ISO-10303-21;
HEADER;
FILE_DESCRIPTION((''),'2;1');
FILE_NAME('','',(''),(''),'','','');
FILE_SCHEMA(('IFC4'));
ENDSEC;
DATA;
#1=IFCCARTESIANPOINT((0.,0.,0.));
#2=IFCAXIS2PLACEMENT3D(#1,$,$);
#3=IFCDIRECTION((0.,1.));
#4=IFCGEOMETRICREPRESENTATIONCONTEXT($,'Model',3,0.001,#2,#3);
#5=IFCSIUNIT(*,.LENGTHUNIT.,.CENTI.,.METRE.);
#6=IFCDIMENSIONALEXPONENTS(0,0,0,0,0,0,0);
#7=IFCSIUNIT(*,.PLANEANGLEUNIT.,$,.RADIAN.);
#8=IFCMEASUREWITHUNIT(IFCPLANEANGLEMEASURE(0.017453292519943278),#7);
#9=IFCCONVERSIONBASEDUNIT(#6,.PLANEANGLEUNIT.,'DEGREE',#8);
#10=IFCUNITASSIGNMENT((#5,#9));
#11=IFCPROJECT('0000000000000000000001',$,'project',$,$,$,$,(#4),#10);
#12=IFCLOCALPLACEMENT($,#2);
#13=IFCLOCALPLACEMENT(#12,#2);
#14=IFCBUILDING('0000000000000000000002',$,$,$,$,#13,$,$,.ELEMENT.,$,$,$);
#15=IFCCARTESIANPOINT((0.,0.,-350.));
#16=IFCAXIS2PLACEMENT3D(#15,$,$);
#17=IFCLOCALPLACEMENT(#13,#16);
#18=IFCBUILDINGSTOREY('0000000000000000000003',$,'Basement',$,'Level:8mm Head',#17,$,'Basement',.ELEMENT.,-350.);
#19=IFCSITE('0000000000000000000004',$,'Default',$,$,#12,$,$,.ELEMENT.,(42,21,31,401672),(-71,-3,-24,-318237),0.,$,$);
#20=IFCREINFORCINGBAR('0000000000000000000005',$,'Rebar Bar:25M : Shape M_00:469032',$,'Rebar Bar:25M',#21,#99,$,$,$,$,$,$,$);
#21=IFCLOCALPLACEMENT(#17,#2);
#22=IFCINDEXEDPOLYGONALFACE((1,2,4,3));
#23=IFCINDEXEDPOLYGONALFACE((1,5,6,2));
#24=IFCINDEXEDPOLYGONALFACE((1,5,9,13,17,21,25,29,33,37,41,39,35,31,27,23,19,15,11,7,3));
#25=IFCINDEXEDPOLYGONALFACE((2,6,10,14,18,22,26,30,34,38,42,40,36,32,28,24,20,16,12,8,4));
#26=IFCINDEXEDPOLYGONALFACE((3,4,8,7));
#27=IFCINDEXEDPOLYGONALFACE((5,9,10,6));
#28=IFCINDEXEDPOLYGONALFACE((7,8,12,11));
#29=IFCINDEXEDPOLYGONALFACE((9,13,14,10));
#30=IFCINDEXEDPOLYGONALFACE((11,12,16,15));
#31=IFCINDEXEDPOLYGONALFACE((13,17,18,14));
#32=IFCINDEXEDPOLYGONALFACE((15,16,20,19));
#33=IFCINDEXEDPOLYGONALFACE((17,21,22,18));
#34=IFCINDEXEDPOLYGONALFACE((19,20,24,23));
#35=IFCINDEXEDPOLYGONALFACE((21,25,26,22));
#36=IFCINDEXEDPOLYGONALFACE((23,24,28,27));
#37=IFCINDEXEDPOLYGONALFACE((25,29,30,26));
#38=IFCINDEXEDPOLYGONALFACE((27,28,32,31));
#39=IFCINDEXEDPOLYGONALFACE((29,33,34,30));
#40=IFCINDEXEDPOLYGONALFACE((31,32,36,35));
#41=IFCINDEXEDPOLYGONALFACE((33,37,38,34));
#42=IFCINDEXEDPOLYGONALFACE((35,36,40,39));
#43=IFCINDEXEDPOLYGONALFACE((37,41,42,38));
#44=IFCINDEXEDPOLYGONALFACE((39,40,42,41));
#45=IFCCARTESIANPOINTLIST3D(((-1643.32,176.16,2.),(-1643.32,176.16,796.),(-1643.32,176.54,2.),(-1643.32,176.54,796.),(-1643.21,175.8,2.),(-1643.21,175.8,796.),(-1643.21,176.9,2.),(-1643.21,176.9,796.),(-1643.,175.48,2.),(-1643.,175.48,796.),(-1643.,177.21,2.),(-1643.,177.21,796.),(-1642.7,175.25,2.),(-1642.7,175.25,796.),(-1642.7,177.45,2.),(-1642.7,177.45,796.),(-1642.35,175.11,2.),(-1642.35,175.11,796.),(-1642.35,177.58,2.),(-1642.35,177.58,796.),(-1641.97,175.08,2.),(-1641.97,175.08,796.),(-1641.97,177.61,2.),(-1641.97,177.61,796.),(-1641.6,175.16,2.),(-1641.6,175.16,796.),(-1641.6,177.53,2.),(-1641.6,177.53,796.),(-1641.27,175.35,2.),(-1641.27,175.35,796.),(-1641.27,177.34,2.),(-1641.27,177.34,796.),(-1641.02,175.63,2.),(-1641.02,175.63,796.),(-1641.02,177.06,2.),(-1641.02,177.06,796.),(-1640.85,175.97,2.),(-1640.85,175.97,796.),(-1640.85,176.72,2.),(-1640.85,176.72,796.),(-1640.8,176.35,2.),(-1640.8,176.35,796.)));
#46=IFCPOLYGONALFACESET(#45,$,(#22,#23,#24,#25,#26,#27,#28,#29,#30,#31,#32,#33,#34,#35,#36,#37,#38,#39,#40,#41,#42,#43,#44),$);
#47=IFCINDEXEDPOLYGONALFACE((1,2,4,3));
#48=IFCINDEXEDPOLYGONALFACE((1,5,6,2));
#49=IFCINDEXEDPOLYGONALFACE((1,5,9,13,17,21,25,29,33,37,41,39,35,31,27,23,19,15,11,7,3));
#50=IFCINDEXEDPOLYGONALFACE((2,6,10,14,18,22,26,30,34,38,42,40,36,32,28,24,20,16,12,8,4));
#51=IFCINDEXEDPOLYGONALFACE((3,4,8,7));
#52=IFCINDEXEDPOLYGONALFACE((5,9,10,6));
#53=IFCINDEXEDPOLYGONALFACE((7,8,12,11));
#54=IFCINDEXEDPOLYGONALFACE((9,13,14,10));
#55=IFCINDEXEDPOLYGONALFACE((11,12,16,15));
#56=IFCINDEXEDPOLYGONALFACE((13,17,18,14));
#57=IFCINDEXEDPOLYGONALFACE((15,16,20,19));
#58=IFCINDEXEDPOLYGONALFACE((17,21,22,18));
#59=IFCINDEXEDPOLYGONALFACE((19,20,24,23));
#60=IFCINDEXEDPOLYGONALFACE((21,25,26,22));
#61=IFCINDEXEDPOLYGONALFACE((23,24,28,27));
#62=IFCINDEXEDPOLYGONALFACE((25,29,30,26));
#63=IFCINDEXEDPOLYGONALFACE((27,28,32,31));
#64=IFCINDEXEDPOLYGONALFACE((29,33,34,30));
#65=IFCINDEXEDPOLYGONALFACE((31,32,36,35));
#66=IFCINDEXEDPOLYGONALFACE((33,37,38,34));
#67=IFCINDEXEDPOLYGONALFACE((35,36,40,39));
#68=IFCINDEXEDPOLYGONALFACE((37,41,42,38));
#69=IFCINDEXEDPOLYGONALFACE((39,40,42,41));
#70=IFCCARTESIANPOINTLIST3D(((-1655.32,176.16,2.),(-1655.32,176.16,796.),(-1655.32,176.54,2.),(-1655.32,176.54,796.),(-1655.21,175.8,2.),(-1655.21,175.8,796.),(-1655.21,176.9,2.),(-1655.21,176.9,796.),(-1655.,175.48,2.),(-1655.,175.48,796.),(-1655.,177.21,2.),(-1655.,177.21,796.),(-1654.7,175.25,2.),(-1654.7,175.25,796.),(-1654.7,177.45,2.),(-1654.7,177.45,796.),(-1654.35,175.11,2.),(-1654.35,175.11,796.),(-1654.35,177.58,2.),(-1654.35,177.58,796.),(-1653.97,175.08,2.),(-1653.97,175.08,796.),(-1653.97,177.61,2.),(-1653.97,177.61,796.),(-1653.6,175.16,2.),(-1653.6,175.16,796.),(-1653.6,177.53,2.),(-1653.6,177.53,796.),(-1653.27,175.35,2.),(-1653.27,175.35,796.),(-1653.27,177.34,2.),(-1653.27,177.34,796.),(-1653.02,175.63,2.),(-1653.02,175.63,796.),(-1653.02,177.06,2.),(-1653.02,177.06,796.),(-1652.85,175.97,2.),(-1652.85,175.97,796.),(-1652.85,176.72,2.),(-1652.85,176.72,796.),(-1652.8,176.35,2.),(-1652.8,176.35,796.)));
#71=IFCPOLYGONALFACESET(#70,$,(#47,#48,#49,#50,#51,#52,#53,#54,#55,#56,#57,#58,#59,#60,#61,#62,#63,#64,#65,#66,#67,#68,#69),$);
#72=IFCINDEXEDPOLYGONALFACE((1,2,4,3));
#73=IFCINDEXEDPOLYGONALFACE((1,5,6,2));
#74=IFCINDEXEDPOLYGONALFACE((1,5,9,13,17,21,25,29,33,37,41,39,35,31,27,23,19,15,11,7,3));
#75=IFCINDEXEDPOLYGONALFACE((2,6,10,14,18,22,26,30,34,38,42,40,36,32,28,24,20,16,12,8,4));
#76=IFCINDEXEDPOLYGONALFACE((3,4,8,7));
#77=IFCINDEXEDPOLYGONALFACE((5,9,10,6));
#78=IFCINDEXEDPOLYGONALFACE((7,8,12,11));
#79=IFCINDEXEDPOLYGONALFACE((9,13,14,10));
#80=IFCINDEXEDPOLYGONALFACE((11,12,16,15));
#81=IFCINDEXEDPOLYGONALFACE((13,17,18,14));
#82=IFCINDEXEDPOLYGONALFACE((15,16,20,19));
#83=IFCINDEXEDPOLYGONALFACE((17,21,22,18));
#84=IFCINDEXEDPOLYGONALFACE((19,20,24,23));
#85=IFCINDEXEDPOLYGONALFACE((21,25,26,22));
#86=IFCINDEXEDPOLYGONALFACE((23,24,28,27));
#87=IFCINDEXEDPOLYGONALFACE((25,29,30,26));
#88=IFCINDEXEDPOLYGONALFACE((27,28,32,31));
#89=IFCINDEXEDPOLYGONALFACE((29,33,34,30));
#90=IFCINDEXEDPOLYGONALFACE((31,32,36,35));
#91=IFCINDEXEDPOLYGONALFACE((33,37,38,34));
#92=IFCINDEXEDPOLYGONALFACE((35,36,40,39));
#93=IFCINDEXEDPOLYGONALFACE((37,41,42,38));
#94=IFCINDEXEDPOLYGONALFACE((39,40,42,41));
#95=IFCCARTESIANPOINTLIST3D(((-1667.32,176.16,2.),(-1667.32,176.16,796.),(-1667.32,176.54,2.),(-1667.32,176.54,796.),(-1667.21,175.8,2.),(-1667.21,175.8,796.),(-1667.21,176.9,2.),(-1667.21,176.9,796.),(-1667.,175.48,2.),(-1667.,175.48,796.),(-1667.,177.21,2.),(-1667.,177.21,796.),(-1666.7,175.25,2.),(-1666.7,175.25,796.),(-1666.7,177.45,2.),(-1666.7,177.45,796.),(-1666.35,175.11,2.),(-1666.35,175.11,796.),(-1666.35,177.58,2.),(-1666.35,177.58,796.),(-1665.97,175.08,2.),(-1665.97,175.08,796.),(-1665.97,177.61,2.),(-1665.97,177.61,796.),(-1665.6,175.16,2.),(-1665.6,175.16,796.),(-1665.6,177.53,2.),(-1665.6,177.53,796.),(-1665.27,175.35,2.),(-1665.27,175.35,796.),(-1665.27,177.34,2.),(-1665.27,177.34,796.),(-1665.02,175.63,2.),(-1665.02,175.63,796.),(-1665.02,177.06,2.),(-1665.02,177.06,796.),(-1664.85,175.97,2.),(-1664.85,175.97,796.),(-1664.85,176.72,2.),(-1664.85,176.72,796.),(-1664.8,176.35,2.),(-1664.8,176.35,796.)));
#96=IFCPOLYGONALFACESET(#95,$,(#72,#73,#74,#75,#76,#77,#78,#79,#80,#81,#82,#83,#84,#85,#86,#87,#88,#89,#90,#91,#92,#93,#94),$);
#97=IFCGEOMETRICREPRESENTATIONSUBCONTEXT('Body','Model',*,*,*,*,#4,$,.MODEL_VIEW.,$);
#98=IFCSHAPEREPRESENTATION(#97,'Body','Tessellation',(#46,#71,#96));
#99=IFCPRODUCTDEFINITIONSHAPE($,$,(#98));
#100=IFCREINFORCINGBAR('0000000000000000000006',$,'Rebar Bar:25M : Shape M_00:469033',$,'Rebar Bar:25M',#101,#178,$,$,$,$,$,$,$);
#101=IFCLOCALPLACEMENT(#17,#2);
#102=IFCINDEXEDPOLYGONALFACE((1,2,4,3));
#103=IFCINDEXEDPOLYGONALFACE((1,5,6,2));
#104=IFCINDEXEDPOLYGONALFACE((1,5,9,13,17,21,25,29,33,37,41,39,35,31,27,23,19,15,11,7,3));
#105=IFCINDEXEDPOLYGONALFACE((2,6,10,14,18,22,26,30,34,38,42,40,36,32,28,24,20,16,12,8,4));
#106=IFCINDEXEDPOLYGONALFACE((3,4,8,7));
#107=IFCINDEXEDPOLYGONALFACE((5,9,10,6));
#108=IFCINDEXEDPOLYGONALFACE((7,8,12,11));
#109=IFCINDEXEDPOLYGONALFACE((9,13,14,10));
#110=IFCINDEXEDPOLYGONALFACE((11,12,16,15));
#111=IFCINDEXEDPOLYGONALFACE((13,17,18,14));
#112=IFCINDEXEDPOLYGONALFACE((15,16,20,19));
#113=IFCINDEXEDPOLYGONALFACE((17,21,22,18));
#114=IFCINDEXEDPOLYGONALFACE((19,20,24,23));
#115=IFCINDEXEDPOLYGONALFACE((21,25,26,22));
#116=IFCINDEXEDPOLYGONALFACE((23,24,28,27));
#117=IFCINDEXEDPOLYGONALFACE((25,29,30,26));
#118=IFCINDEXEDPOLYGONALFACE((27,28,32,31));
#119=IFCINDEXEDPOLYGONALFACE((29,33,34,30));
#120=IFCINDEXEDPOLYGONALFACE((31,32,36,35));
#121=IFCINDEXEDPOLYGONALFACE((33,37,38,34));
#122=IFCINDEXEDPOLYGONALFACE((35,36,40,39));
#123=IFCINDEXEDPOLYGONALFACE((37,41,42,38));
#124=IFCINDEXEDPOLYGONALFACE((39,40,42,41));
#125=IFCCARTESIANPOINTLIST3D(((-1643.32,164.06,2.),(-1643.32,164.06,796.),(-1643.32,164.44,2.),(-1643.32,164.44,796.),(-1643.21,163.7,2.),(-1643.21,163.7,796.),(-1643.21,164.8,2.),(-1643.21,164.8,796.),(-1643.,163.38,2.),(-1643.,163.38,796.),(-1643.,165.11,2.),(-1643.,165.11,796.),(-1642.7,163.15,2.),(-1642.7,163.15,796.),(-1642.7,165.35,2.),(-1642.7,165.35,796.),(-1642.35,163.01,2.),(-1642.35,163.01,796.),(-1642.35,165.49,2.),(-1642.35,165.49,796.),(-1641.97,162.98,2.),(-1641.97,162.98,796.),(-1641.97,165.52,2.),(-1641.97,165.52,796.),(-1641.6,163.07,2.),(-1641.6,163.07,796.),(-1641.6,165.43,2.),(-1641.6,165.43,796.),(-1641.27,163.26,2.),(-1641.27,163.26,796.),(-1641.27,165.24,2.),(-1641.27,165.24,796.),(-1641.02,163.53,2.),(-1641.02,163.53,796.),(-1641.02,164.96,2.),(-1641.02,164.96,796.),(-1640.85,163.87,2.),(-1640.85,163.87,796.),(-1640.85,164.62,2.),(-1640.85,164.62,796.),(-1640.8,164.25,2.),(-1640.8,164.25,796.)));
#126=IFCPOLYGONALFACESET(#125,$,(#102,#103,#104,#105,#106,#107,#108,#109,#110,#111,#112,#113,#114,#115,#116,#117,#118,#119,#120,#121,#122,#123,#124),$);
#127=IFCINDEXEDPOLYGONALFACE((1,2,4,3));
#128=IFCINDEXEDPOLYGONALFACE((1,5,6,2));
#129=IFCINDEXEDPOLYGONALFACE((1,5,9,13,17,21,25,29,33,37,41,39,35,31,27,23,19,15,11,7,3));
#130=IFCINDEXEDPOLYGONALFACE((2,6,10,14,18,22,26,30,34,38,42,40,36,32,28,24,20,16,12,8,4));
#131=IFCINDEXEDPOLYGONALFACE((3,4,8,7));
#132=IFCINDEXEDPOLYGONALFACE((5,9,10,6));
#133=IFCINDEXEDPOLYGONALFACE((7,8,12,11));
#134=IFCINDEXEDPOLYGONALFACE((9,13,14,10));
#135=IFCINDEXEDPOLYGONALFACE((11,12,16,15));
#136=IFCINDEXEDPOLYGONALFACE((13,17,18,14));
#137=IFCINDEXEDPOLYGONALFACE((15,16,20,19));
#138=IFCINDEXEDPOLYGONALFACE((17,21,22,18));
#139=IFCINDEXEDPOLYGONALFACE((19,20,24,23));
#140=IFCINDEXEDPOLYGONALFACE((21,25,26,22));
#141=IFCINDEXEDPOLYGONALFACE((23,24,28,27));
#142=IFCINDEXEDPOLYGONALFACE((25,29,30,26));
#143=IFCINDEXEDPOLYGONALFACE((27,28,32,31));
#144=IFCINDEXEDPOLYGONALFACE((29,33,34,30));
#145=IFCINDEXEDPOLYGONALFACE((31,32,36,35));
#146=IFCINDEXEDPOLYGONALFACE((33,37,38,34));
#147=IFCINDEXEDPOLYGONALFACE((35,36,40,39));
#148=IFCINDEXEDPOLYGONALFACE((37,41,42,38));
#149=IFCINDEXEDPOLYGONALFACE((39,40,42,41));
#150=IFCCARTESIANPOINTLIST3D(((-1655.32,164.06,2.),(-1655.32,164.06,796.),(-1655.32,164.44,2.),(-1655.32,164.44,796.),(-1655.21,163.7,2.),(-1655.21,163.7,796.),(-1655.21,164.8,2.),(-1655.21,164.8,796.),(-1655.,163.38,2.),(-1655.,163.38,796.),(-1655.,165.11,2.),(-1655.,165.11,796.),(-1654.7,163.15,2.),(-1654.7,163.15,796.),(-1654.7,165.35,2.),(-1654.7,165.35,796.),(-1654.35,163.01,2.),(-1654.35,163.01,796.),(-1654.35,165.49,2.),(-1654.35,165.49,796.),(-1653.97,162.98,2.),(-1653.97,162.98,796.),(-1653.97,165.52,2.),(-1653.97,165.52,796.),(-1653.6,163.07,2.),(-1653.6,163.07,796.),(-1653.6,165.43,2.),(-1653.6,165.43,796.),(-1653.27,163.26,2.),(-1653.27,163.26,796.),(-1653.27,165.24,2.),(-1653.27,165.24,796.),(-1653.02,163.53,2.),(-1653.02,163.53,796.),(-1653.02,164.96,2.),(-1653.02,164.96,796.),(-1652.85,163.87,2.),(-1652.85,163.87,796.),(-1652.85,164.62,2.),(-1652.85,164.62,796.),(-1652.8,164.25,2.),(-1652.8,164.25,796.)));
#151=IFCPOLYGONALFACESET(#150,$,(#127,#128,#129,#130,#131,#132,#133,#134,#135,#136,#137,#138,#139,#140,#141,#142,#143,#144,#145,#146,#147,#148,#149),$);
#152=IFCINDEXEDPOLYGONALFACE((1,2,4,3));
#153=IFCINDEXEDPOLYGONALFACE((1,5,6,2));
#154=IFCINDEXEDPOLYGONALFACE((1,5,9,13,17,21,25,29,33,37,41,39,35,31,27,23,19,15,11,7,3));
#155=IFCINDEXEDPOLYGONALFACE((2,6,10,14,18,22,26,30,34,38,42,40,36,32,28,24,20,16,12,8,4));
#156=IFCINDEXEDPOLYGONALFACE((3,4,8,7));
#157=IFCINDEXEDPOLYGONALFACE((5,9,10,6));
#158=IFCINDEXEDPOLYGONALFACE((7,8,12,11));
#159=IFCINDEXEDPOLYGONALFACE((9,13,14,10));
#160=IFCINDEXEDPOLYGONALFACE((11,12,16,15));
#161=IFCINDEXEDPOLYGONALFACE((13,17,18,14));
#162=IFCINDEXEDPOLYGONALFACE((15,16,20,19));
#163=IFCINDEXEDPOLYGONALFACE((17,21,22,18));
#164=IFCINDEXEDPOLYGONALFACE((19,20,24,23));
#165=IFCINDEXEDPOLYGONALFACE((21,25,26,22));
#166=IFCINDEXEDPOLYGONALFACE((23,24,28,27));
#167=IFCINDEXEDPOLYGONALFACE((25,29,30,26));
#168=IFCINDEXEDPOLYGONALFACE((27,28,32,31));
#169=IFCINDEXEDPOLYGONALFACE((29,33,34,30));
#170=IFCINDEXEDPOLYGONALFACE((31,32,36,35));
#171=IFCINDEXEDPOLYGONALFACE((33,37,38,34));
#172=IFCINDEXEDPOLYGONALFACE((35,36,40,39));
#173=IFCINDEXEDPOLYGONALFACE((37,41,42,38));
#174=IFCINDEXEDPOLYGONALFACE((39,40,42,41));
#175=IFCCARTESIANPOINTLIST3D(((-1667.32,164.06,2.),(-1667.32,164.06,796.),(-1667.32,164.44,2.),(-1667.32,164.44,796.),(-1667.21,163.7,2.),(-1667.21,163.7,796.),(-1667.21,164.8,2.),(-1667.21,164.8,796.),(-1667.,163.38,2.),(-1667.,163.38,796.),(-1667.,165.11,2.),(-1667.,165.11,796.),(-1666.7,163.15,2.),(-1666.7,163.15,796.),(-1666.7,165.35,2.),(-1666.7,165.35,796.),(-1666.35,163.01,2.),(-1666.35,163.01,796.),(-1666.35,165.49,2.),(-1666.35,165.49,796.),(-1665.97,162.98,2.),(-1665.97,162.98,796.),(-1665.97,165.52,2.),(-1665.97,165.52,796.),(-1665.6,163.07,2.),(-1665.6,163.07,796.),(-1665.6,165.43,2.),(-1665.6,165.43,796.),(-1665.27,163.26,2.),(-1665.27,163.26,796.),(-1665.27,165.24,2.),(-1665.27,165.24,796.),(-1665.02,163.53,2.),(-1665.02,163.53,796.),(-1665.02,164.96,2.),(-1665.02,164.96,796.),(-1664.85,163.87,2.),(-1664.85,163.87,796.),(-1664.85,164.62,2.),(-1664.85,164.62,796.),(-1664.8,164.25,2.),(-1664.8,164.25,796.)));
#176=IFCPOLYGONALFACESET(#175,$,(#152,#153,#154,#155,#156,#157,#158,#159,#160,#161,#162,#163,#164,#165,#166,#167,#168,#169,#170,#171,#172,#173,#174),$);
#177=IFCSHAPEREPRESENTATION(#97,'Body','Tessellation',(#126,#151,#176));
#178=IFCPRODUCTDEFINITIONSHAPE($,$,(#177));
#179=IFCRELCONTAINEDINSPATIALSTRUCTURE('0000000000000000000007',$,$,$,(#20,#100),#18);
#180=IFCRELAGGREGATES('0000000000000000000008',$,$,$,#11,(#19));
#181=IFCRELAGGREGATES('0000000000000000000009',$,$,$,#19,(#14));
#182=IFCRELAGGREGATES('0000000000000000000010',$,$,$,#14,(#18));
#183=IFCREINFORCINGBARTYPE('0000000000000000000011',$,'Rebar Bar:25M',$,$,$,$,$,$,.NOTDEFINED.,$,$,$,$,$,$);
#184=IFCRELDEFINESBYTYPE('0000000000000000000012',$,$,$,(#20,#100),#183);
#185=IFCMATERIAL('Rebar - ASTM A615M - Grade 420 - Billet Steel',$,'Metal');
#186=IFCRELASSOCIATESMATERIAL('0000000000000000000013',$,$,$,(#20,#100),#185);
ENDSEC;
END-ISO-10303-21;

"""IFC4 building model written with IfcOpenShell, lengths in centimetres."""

from ifc_helpers import new_model, entity, si_unit, converted_unit, direction, frame, origin, place, context, subcontext, project, spatial, material, type_object, element, save


model = new_model("IFC4")

# Units and contexts
model_context = context("Model", 3, precision=0.001, world=origin(), true_north=direction((0.0, 1.0)))
body_context = subcontext(model_context, "Body", "Model", "MODEL_VIEW")
ifc_project = project(units=[si_unit("LENGTHUNIT", "METRE", prefix="CENTI"), converted_unit("PLANEANGLEUNIT", "DEGREE", entity("IfcPlaneAngleMeasure", 0.017453292519943278), si_unit("PLANEANGLEUNIT", "RADIAN"), dimensions=[0, 0, 0, 0, 0, 0, 0])], contexts=[model_context])

# Site, building, storey
site_placement = place(None, origin())
site = spatial("IfcSite", under=ifc_project, at=site_placement, Name="Default", CompositionType="ELEMENT", RefLatitude=(42, 21, 31, 401672), RefLongitude=(-71, -3, -24, -318237), RefElevation=0.0)
building_placement = place(site_placement, origin())
building = spatial("IfcBuilding", under=site, at=building_placement, CompositionType="ELEMENT")
storey_placement = place(building_placement, frame((0.0, 0.0, -350.0)))
storey = spatial("IfcBuildingStorey", under=building, at=storey_placement, Name="Basement", ObjectType="Level:8mm Head", LongName="Basement", CompositionType="ELEMENT", Elevation=-350.0)

# Reinforcing bars
ifc_material_1 = material(Name="Rebar - ASTM A615M - Grade 420 - Billet Steel", Category="Metal")
reinforcing_bar_type_1 = type_object("IfcReinforcingBarType", Name="Rebar Bar:25M", PredefinedType="NOTDEFINED")
reinforcing_bar_1_placement = place(storey_placement, origin())
element("IfcReinforcingBar", 1, at=reinforcing_bar_1_placement, inside=storey, type_object=reinforcing_bar_type_1, material=ifc_material_1, Name="Rebar Bar:25M : Shape M_00:469032", ObjectType="Rebar Bar:25M", context=body_context, shape_type="AdvancedSweptSolid", body=[
    entity("IfcSweptDiskSolid", entity("IfcIndexedPolyCurve", entity("IfcCartesianPointList3D", [[-1642.07, 176.35, 2.0], [-1642.07, 176.35, 796.0]]), None, False), 1.27, None, 0.0, 1.0),
    entity("IfcSweptDiskSolid", entity("IfcIndexedPolyCurve", entity("IfcCartesianPointList3D", [[-1654.07, 176.35, 2.0], [-1654.07, 176.35, 796.0]]), None, False), 1.27, None, 0.0, 1.0),
    entity("IfcSweptDiskSolid", entity("IfcIndexedPolyCurve", entity("IfcCartesianPointList3D", [[-1666.07, 176.35, 2.0], [-1666.07, 176.35, 796.0]]), None, False), 1.27, None, 0.0, 1.0),
])
reinforcing_bar_2_placement = place(storey_placement, origin())
element("IfcReinforcingBar", 2, at=reinforcing_bar_2_placement, inside=storey, type_object=reinforcing_bar_type_1, material=ifc_material_1, Name="Rebar Bar:25M : Shape M_00:469033", ObjectType="Rebar Bar:25M", context=body_context, shape_type="AdvancedSweptSolid", body=[
    entity("IfcSweptDiskSolid", entity("IfcIndexedPolyCurve", entity("IfcCartesianPointList3D", [[-1642.07, 164.25, 2.0], [-1642.07, 164.25, 796.0]]), None, False), 1.27, None, 0.0, 1.0),
    entity("IfcSweptDiskSolid", entity("IfcIndexedPolyCurve", entity("IfcCartesianPointList3D", [[-1654.07, 164.25, 2.0], [-1654.07, 164.25, 796.0]]), None, False), 1.27, None, 0.0, 1.0),
    entity("IfcSweptDiskSolid", entity("IfcIndexedPolyCurve", entity("IfcCartesianPointList3D", [[-1666.07, 164.25, 2.0], [-1666.07, 164.25, 796.0]]), None, False), 1.27, None, 0.0, 1.0),
])

save(model, "model.ifc")
